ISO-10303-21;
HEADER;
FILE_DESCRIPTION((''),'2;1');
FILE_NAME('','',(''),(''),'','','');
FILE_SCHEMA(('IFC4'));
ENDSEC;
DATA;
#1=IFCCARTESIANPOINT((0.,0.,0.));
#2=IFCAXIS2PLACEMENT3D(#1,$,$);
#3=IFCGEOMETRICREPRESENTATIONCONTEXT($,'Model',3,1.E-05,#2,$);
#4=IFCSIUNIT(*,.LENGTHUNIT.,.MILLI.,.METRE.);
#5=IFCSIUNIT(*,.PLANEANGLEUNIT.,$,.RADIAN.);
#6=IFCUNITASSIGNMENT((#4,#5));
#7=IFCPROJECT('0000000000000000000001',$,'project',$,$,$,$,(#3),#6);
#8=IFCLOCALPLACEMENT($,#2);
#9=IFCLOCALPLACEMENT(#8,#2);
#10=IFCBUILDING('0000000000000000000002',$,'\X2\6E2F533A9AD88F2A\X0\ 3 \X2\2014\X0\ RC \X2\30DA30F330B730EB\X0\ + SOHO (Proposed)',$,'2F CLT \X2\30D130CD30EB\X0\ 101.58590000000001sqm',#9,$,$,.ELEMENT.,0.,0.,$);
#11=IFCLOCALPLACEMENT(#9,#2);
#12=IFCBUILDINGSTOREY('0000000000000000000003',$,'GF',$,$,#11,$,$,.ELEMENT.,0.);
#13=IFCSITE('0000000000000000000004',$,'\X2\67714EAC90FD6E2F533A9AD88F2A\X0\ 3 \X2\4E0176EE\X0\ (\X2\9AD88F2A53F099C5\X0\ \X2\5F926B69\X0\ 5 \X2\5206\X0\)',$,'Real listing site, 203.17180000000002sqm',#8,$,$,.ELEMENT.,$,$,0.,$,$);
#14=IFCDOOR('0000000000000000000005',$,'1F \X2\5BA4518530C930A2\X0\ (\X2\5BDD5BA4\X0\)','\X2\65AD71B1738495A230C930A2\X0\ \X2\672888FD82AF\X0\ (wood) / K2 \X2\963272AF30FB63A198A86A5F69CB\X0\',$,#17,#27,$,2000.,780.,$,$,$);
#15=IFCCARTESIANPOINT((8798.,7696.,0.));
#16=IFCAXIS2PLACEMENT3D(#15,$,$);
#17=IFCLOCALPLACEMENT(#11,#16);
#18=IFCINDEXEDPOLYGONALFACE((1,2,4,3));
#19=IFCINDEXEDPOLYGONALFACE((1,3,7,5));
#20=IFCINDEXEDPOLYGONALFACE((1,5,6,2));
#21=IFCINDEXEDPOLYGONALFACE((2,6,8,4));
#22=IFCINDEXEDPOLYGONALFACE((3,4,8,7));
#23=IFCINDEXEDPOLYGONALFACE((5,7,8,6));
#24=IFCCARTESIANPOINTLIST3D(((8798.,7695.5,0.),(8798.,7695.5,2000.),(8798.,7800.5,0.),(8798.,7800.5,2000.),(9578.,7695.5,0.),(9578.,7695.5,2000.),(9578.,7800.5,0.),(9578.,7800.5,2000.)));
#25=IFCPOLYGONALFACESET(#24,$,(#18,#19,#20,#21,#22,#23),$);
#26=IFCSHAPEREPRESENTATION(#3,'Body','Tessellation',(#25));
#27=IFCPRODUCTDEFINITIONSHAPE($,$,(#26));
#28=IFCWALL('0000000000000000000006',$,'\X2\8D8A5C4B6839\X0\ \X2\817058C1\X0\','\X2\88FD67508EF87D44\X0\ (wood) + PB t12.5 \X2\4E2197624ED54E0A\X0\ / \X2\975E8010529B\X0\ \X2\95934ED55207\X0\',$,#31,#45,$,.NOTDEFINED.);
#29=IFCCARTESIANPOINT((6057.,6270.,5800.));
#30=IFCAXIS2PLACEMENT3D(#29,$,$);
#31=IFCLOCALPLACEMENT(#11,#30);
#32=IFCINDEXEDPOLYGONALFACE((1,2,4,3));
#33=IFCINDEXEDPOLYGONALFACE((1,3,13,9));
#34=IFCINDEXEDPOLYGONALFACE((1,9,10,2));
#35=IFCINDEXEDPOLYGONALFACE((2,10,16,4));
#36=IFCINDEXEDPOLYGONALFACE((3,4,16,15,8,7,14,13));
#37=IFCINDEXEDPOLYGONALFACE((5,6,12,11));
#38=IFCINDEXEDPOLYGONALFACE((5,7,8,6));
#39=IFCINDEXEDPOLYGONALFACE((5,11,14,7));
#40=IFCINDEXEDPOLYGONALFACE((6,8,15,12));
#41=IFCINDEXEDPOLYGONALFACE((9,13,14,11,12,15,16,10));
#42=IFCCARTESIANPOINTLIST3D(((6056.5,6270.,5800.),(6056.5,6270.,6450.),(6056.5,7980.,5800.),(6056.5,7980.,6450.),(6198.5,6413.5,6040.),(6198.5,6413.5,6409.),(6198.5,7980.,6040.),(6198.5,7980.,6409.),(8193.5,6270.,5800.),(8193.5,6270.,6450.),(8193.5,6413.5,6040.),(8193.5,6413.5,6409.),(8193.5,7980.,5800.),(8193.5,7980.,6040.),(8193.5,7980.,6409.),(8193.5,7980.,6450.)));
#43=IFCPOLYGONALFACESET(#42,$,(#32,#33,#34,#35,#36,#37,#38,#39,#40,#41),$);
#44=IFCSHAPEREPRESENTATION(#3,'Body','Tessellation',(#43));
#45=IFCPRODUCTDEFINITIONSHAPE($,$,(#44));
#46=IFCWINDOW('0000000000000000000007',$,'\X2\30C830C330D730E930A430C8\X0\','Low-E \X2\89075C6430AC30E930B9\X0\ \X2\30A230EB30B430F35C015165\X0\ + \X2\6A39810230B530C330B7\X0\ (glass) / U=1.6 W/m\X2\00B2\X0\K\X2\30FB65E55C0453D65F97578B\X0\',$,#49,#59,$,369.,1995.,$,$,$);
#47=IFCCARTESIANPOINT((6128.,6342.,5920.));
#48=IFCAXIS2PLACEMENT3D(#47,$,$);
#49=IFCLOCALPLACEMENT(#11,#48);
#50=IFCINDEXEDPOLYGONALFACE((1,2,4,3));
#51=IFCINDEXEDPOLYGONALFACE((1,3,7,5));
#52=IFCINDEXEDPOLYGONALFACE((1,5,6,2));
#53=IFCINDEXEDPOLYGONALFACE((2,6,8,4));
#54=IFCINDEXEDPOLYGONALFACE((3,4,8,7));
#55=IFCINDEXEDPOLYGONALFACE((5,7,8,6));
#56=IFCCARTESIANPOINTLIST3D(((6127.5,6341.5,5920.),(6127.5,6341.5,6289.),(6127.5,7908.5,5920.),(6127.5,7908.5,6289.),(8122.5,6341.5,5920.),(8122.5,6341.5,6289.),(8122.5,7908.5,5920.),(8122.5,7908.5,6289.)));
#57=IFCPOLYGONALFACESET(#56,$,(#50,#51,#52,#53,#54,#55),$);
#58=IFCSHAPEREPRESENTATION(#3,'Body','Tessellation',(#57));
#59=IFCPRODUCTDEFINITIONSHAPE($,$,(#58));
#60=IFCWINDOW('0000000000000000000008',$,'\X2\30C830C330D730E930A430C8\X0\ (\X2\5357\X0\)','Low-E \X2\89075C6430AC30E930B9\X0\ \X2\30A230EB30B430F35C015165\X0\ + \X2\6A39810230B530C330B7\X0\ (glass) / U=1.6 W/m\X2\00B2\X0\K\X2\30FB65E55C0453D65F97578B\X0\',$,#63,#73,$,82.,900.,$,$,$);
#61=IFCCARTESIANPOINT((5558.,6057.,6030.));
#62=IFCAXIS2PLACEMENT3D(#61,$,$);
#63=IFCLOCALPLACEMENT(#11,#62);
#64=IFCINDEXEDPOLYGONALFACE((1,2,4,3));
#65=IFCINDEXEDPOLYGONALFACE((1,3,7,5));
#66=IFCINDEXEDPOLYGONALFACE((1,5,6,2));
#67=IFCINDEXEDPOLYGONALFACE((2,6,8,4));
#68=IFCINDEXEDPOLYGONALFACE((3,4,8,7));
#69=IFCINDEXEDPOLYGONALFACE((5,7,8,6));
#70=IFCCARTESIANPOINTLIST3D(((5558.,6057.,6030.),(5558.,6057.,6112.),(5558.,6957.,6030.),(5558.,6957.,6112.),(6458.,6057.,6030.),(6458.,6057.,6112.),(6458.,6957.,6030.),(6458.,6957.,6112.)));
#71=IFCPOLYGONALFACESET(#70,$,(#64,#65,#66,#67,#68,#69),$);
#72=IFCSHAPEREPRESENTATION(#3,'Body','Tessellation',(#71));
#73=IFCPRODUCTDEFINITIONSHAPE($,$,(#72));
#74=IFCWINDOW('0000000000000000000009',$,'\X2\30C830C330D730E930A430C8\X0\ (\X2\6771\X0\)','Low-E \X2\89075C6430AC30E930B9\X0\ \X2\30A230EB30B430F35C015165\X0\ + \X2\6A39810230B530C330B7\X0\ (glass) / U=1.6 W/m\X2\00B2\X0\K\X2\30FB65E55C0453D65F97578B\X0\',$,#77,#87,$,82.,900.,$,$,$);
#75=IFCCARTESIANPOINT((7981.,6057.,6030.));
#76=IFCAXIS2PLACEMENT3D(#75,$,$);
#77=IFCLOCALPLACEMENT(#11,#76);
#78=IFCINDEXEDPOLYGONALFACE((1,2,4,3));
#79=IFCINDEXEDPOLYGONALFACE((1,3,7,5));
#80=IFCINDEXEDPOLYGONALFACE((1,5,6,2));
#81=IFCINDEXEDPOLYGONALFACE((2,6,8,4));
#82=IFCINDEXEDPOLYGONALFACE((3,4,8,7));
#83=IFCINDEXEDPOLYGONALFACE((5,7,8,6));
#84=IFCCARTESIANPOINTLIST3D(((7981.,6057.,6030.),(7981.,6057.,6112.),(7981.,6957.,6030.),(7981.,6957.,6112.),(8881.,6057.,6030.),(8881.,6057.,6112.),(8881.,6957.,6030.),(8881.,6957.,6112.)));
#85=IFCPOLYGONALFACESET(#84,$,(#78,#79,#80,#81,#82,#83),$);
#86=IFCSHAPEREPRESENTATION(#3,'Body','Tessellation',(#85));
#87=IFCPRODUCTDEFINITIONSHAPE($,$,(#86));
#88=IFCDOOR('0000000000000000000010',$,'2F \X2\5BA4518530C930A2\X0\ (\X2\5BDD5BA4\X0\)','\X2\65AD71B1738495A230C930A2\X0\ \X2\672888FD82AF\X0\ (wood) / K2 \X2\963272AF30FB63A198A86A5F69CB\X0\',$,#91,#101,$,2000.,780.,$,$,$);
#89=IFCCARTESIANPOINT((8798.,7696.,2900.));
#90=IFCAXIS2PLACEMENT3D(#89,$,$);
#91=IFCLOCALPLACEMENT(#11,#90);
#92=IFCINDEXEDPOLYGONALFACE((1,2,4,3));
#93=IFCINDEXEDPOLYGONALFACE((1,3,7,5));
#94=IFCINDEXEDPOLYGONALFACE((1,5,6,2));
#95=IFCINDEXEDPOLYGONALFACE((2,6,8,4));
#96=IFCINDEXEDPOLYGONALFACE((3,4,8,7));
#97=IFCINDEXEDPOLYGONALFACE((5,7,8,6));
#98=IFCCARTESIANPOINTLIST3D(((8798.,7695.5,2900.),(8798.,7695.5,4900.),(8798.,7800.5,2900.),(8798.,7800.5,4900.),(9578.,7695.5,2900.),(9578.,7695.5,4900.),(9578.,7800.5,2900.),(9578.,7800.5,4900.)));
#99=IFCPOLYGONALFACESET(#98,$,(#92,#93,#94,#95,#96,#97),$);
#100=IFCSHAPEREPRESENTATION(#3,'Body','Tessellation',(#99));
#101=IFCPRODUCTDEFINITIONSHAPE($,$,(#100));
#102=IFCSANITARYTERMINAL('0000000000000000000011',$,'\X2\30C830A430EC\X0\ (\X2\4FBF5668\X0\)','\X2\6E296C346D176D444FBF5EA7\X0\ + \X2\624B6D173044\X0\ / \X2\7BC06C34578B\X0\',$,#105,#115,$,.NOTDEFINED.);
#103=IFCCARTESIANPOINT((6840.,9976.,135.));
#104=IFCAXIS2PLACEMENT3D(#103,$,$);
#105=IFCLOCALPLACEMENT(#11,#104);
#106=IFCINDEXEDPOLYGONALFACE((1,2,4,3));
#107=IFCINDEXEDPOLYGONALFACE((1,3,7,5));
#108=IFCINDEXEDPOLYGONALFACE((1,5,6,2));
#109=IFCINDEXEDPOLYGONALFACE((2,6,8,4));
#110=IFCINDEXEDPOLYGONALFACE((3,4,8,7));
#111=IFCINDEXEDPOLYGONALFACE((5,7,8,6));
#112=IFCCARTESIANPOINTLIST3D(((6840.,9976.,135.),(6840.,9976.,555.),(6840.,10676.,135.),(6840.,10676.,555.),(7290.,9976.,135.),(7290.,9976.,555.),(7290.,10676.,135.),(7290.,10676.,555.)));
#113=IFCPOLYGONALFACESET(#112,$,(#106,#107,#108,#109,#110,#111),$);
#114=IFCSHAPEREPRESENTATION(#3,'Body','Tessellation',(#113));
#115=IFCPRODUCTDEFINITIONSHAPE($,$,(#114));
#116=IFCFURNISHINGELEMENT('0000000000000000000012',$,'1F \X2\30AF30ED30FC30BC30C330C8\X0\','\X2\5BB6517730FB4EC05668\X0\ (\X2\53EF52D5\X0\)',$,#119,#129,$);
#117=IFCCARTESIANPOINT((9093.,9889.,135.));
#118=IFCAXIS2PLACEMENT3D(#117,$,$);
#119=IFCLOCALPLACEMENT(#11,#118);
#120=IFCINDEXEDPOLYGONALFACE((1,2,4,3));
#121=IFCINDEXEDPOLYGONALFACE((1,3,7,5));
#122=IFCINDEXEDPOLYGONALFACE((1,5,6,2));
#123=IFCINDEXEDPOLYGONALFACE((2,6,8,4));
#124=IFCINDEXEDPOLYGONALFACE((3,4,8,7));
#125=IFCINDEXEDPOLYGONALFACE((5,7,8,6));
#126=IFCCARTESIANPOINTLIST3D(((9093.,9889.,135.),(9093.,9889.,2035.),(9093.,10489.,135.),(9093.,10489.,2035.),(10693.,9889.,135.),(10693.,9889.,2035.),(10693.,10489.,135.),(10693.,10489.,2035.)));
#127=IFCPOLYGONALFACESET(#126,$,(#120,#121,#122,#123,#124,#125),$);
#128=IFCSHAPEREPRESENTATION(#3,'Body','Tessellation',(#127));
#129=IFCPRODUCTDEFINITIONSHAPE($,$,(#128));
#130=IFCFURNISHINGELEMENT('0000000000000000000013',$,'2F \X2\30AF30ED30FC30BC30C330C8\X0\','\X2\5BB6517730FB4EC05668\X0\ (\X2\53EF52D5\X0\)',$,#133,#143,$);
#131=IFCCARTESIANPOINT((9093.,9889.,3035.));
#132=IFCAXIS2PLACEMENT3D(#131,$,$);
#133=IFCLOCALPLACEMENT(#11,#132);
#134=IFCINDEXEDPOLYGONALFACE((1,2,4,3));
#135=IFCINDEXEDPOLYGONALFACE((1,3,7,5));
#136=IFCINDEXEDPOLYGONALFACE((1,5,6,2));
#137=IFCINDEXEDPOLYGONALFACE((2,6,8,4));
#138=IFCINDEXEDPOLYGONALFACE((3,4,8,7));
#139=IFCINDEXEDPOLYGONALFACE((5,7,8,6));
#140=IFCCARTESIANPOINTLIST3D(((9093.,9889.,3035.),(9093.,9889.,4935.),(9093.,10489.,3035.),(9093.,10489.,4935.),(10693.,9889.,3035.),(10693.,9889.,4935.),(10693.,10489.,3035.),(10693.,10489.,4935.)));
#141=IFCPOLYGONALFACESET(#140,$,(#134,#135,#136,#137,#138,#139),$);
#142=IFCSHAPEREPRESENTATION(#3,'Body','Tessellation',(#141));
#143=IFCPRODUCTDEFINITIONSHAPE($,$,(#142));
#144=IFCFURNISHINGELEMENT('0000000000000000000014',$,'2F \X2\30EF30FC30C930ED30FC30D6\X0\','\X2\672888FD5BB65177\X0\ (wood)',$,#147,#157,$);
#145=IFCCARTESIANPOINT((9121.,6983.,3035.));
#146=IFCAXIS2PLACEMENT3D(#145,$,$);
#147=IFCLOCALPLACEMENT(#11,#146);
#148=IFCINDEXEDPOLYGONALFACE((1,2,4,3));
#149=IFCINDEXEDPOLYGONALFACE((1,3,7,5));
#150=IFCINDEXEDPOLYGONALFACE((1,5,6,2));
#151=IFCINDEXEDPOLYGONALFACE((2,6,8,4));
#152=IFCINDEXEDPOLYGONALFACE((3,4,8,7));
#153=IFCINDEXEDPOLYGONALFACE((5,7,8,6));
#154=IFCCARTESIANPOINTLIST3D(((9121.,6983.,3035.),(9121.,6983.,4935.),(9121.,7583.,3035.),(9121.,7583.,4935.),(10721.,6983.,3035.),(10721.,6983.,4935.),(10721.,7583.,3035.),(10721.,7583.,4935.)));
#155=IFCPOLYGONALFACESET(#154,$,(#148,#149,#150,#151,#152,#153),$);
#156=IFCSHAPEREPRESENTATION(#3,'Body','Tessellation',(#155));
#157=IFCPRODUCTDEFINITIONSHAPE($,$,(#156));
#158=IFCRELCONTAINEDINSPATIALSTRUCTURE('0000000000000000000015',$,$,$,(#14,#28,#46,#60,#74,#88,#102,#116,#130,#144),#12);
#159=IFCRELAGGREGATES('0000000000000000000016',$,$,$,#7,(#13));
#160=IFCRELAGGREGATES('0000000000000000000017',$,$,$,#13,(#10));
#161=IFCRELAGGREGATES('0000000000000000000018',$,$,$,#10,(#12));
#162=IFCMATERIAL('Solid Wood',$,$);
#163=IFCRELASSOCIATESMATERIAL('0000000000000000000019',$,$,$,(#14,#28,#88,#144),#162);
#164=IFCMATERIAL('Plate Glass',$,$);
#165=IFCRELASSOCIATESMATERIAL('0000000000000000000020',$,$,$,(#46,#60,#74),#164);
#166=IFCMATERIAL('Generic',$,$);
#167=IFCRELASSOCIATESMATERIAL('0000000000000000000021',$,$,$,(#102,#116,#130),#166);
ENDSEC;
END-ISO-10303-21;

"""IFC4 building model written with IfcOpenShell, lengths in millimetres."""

from ifc_helpers import new_model, si_unit, frame, frame_2d, origin, place, context, project, spatial, rectangle, extrude, material, element, fill, save


model = new_model("IFC4")

# Units and contexts
model_context = context("Model", 3, precision=1e-05, world=origin())
ifc_project = project(units=[si_unit("LENGTHUNIT", "METRE", prefix="MILLI"), si_unit("PLANEANGLEUNIT", "RADIAN")], contexts=[model_context])

# Site, building, storey
site_placement = place(None, origin())
site = spatial("IfcSite", under=ifc_project, at=site_placement, Name="東京都港区高輪 3 丁目 (高輪台駅 徒歩 5 分)", ObjectType="Real listing site, 203.17180000000002sqm", CompositionType="ELEMENT", RefElevation=0.0)
building_placement = place(site_placement, origin())
building = spatial("IfcBuilding", under=site, at=building_placement, Name="港区高輪 3 — RC ペンシル + SOHO (Proposed)", ObjectType="2F CLT パネル 101.58590000000001sqm", CompositionType="ELEMENT", ElevationOfRefHeight=0.0, ElevationOfTerrain=0.0)
storey_placement = place(building_placement, origin())
storey = spatial("IfcBuildingStorey", under=building, at=storey_placement, Name="GF", CompositionType="ELEMENT", Elevation=0.0)

# Shared definitions
ifc_material_1 = material(Name="Solid Wood")

# Door
door_1_placement = place(storey_placement, frame((8798.0, 7696.0, 0.0)))
element("IfcDoor", 1, at=door_1_placement, inside=storey, material=ifc_material_1, Name="1F 室内ドア (寝室)", Description="断熱玄関ドア 木製芯 (wood) / K2 防犯・採風機構", OverallHeight=2000.0, OverallWidth=780.0, context=model_context, shape_type="SweptSolid", body=[
    extrude(rectangle(XDim=780.0, YDim=105.0, at=frame_2d((390.0, 52.0))), frame((8798.0, 7696.0, 0.0)), (0.0, 0.0, 1.0), 2000.0),
])

# Wall, openings, windows
wall_1_placement = place(storey_placement, frame((6057.0, 6270.0, 5800.0)))
wall_1 = element("IfcWall", 2, at=wall_1_placement, inside=storey, material=ifc_material_1, Name="越屋根 腰壁", Description="製材軸組 (wood) + PB t12.5 両面仕上 / 非耐力 間仕切", PredefinedType="NOTDEFINED", context=model_context, shape_type="SweptSolid", body=[
    extrude(rectangle(XDim=2137.0, YDim=1710.0, at=frame_2d((1068.0, 855.0))), frame((6057.0, 6270.0, 5800.0)), (0.0, 0.0, 1.0), 650.0),
])
opening_1_placement = place(storey_placement, frame((6128.0, 6342.0, 5920.0)))
opening_1 = element("IfcOpeningElement", 3, at=opening_1_placement, cuts=wall_1, PredefinedType="NOTDEFINED", context=model_context, shape_type="SweptSolid", body=[
    extrude(rectangle(XDim=1995.0, YDim=1567.0, at=frame_2d((997.0, 783.0))), frame((6128.0, 6342.0, 5920.0)), (0.0, 0.0, 1.0), 369.0),
])
opening_2_placement = place(storey_placement, frame((5558.0, 6057.0, 6030.0)))
opening_2 = element("IfcOpeningElement", 4, at=opening_2_placement, cuts=wall_1, PredefinedType="NOTDEFINED", context=model_context, shape_type="SweptSolid", body=[
    extrude(rectangle(XDim=900.0, YDim=900.0, at=frame_2d((450.0, 450.0))), frame((5558.0, 6057.0, 6030.0)), (0.0, 0.0, 1.0), 82.0),
])
opening_3_placement = place(storey_placement, frame((7981.0, 6057.0, 6030.0)))
opening_3 = element("IfcOpeningElement", 5, at=opening_3_placement, cuts=wall_1, PredefinedType="NOTDEFINED", context=model_context, shape_type="SweptSolid", body=[
    extrude(rectangle(XDim=900.0, YDim=900.0, at=frame_2d((450.0, 450.0))), frame((7981.0, 6057.0, 6030.0)), (0.0, 0.0, 1.0), 82.0),
])
ifc_material_2 = material(Name="Plate Glass")
window_1_placement = place(storey_placement, frame((6128.0, 6342.0, 5920.0)))
window_1 = element("IfcWindow", 6, at=window_1_placement, inside=storey, material=ifc_material_2, Name="トップライト", Description="Low-E 複層ガラス アルゴン封入 + 樹脂サッシ (glass) / U=1.6 W/m²K・日射取得型", OverallHeight=369.0, OverallWidth=1995.0, context=model_context, shape_type="SweptSolid", body=[
    extrude(rectangle(XDim=1995.0, YDim=1567.0, at=frame_2d((997.0, 783.0))), frame((6128.0, 6342.0, 5920.0)), (0.0, 0.0, 1.0), 369.0),
])
fill(opening_1, window_1)
window_2_placement = place(storey_placement, frame((5558.0, 6057.0, 6030.0)))
window_2 = element("IfcWindow", 7, at=window_2_placement, inside=storey, material=ifc_material_2, Name="トップライト (南)", Description="Low-E 複層ガラス アルゴン封入 + 樹脂サッシ (glass) / U=1.6 W/m²K・日射取得型", OverallHeight=82.0, OverallWidth=900.0, context=model_context, shape_type="SweptSolid", body=[
    extrude(rectangle(XDim=900.0, YDim=900.0, at=frame_2d((450.0, 450.0))), frame((5558.0, 6057.0, 6030.0)), (0.0, 0.0, 1.0), 82.0),
])
fill(opening_2, window_2)
window_3_placement = place(storey_placement, frame((7981.0, 6057.0, 6030.0)))
window_3 = element("IfcWindow", 8, at=window_3_placement, inside=storey, material=ifc_material_2, Name="トップライト (東)", Description="Low-E 複層ガラス アルゴン封入 + 樹脂サッシ (glass) / U=1.6 W/m²K・日射取得型", OverallHeight=82.0, OverallWidth=900.0, context=model_context, shape_type="SweptSolid", body=[
    extrude(rectangle(XDim=900.0, YDim=900.0, at=frame_2d((450.0, 450.0))), frame((7981.0, 6057.0, 6030.0)), (0.0, 0.0, 1.0), 82.0),
])
fill(opening_3, window_3)

# Door
door_2_placement = place(storey_placement, frame((8798.0, 7696.0, 2900.0)))
element("IfcDoor", 9, at=door_2_placement, inside=storey, material=ifc_material_1, Name="2F 室内ドア (寝室)", Description="断熱玄関ドア 木製芯 (wood) / K2 防犯・採風機構", OverallHeight=2000.0, OverallWidth=780.0, context=model_context, shape_type="SweptSolid", body=[
    extrude(rectangle(XDim=780.0, YDim=105.0, at=frame_2d((390.0, 52.0))), frame((8798.0, 7696.0, 2900.0)), (0.0, 0.0, 1.0), 2000.0),
])

# Sanitary terminal
ifc_material_3 = material(Name="Generic")
sanitary_terminal_placement = place(storey_placement, frame((6840.0, 9976.0, 135.0)))
element("IfcSanitaryTerminal", 10, at=sanitary_terminal_placement, inside=storey, material=ifc_material_3, Name="トイレ (便器)", Description="温水洗浄便座 + 手洗い / 節水型", PredefinedType="NOTDEFINED", context=model_context, shape_type="SweptSolid", body=[
    extrude(rectangle(XDim=450.0, YDim=700.0, at=frame_2d((225.0, 350.0))), frame((6840.0, 9976.0, 135.0)), (0.0, 0.0, 1.0), 420.0),
])

# Furnishing elements
furnishing_1_placement = place(storey_placement, frame((9093.0, 9889.0, 135.0)))
element("IfcFurnishingElement", 11, at=furnishing_1_placement, inside=storey, material=ifc_material_3, Name="1F クローゼット", Description="家具・什器 (可動)", context=model_context, shape_type="SweptSolid", body=[
    extrude(rectangle(XDim=1600.0, YDim=600.0, at=frame_2d((800.0, 300.0))), frame((9093.0, 9889.0, 135.0)), (0.0, 0.0, 1.0), 1900.0),
])
furnishing_2_placement = place(storey_placement, frame((9093.0, 9889.0, 3035.0)))
element("IfcFurnishingElement", 12, at=furnishing_2_placement, inside=storey, material=ifc_material_3, Name="2F クローゼット", Description="家具・什器 (可動)", context=model_context, shape_type="SweptSolid", body=[
    extrude(rectangle(XDim=1600.0, YDim=600.0, at=frame_2d((800.0, 300.0))), frame((9093.0, 9889.0, 3035.0)), (0.0, 0.0, 1.0), 1900.0),
])
furnishing_3_placement = place(storey_placement, frame((9121.0, 6983.0, 3035.0)))
element("IfcFurnishingElement", 13, at=furnishing_3_placement, inside=storey, material=ifc_material_1, Name="2F ワードローブ", Description="木製家具 (wood)", context=model_context, shape_type="SweptSolid", body=[
    extrude(rectangle(XDim=1600.0, YDim=600.0, at=frame_2d((800.0, 300.0))), frame((9121.0, 6983.0, 3035.0)), (0.0, 0.0, 1.0), 1900.0),
])

save(model, "model.ifc")
